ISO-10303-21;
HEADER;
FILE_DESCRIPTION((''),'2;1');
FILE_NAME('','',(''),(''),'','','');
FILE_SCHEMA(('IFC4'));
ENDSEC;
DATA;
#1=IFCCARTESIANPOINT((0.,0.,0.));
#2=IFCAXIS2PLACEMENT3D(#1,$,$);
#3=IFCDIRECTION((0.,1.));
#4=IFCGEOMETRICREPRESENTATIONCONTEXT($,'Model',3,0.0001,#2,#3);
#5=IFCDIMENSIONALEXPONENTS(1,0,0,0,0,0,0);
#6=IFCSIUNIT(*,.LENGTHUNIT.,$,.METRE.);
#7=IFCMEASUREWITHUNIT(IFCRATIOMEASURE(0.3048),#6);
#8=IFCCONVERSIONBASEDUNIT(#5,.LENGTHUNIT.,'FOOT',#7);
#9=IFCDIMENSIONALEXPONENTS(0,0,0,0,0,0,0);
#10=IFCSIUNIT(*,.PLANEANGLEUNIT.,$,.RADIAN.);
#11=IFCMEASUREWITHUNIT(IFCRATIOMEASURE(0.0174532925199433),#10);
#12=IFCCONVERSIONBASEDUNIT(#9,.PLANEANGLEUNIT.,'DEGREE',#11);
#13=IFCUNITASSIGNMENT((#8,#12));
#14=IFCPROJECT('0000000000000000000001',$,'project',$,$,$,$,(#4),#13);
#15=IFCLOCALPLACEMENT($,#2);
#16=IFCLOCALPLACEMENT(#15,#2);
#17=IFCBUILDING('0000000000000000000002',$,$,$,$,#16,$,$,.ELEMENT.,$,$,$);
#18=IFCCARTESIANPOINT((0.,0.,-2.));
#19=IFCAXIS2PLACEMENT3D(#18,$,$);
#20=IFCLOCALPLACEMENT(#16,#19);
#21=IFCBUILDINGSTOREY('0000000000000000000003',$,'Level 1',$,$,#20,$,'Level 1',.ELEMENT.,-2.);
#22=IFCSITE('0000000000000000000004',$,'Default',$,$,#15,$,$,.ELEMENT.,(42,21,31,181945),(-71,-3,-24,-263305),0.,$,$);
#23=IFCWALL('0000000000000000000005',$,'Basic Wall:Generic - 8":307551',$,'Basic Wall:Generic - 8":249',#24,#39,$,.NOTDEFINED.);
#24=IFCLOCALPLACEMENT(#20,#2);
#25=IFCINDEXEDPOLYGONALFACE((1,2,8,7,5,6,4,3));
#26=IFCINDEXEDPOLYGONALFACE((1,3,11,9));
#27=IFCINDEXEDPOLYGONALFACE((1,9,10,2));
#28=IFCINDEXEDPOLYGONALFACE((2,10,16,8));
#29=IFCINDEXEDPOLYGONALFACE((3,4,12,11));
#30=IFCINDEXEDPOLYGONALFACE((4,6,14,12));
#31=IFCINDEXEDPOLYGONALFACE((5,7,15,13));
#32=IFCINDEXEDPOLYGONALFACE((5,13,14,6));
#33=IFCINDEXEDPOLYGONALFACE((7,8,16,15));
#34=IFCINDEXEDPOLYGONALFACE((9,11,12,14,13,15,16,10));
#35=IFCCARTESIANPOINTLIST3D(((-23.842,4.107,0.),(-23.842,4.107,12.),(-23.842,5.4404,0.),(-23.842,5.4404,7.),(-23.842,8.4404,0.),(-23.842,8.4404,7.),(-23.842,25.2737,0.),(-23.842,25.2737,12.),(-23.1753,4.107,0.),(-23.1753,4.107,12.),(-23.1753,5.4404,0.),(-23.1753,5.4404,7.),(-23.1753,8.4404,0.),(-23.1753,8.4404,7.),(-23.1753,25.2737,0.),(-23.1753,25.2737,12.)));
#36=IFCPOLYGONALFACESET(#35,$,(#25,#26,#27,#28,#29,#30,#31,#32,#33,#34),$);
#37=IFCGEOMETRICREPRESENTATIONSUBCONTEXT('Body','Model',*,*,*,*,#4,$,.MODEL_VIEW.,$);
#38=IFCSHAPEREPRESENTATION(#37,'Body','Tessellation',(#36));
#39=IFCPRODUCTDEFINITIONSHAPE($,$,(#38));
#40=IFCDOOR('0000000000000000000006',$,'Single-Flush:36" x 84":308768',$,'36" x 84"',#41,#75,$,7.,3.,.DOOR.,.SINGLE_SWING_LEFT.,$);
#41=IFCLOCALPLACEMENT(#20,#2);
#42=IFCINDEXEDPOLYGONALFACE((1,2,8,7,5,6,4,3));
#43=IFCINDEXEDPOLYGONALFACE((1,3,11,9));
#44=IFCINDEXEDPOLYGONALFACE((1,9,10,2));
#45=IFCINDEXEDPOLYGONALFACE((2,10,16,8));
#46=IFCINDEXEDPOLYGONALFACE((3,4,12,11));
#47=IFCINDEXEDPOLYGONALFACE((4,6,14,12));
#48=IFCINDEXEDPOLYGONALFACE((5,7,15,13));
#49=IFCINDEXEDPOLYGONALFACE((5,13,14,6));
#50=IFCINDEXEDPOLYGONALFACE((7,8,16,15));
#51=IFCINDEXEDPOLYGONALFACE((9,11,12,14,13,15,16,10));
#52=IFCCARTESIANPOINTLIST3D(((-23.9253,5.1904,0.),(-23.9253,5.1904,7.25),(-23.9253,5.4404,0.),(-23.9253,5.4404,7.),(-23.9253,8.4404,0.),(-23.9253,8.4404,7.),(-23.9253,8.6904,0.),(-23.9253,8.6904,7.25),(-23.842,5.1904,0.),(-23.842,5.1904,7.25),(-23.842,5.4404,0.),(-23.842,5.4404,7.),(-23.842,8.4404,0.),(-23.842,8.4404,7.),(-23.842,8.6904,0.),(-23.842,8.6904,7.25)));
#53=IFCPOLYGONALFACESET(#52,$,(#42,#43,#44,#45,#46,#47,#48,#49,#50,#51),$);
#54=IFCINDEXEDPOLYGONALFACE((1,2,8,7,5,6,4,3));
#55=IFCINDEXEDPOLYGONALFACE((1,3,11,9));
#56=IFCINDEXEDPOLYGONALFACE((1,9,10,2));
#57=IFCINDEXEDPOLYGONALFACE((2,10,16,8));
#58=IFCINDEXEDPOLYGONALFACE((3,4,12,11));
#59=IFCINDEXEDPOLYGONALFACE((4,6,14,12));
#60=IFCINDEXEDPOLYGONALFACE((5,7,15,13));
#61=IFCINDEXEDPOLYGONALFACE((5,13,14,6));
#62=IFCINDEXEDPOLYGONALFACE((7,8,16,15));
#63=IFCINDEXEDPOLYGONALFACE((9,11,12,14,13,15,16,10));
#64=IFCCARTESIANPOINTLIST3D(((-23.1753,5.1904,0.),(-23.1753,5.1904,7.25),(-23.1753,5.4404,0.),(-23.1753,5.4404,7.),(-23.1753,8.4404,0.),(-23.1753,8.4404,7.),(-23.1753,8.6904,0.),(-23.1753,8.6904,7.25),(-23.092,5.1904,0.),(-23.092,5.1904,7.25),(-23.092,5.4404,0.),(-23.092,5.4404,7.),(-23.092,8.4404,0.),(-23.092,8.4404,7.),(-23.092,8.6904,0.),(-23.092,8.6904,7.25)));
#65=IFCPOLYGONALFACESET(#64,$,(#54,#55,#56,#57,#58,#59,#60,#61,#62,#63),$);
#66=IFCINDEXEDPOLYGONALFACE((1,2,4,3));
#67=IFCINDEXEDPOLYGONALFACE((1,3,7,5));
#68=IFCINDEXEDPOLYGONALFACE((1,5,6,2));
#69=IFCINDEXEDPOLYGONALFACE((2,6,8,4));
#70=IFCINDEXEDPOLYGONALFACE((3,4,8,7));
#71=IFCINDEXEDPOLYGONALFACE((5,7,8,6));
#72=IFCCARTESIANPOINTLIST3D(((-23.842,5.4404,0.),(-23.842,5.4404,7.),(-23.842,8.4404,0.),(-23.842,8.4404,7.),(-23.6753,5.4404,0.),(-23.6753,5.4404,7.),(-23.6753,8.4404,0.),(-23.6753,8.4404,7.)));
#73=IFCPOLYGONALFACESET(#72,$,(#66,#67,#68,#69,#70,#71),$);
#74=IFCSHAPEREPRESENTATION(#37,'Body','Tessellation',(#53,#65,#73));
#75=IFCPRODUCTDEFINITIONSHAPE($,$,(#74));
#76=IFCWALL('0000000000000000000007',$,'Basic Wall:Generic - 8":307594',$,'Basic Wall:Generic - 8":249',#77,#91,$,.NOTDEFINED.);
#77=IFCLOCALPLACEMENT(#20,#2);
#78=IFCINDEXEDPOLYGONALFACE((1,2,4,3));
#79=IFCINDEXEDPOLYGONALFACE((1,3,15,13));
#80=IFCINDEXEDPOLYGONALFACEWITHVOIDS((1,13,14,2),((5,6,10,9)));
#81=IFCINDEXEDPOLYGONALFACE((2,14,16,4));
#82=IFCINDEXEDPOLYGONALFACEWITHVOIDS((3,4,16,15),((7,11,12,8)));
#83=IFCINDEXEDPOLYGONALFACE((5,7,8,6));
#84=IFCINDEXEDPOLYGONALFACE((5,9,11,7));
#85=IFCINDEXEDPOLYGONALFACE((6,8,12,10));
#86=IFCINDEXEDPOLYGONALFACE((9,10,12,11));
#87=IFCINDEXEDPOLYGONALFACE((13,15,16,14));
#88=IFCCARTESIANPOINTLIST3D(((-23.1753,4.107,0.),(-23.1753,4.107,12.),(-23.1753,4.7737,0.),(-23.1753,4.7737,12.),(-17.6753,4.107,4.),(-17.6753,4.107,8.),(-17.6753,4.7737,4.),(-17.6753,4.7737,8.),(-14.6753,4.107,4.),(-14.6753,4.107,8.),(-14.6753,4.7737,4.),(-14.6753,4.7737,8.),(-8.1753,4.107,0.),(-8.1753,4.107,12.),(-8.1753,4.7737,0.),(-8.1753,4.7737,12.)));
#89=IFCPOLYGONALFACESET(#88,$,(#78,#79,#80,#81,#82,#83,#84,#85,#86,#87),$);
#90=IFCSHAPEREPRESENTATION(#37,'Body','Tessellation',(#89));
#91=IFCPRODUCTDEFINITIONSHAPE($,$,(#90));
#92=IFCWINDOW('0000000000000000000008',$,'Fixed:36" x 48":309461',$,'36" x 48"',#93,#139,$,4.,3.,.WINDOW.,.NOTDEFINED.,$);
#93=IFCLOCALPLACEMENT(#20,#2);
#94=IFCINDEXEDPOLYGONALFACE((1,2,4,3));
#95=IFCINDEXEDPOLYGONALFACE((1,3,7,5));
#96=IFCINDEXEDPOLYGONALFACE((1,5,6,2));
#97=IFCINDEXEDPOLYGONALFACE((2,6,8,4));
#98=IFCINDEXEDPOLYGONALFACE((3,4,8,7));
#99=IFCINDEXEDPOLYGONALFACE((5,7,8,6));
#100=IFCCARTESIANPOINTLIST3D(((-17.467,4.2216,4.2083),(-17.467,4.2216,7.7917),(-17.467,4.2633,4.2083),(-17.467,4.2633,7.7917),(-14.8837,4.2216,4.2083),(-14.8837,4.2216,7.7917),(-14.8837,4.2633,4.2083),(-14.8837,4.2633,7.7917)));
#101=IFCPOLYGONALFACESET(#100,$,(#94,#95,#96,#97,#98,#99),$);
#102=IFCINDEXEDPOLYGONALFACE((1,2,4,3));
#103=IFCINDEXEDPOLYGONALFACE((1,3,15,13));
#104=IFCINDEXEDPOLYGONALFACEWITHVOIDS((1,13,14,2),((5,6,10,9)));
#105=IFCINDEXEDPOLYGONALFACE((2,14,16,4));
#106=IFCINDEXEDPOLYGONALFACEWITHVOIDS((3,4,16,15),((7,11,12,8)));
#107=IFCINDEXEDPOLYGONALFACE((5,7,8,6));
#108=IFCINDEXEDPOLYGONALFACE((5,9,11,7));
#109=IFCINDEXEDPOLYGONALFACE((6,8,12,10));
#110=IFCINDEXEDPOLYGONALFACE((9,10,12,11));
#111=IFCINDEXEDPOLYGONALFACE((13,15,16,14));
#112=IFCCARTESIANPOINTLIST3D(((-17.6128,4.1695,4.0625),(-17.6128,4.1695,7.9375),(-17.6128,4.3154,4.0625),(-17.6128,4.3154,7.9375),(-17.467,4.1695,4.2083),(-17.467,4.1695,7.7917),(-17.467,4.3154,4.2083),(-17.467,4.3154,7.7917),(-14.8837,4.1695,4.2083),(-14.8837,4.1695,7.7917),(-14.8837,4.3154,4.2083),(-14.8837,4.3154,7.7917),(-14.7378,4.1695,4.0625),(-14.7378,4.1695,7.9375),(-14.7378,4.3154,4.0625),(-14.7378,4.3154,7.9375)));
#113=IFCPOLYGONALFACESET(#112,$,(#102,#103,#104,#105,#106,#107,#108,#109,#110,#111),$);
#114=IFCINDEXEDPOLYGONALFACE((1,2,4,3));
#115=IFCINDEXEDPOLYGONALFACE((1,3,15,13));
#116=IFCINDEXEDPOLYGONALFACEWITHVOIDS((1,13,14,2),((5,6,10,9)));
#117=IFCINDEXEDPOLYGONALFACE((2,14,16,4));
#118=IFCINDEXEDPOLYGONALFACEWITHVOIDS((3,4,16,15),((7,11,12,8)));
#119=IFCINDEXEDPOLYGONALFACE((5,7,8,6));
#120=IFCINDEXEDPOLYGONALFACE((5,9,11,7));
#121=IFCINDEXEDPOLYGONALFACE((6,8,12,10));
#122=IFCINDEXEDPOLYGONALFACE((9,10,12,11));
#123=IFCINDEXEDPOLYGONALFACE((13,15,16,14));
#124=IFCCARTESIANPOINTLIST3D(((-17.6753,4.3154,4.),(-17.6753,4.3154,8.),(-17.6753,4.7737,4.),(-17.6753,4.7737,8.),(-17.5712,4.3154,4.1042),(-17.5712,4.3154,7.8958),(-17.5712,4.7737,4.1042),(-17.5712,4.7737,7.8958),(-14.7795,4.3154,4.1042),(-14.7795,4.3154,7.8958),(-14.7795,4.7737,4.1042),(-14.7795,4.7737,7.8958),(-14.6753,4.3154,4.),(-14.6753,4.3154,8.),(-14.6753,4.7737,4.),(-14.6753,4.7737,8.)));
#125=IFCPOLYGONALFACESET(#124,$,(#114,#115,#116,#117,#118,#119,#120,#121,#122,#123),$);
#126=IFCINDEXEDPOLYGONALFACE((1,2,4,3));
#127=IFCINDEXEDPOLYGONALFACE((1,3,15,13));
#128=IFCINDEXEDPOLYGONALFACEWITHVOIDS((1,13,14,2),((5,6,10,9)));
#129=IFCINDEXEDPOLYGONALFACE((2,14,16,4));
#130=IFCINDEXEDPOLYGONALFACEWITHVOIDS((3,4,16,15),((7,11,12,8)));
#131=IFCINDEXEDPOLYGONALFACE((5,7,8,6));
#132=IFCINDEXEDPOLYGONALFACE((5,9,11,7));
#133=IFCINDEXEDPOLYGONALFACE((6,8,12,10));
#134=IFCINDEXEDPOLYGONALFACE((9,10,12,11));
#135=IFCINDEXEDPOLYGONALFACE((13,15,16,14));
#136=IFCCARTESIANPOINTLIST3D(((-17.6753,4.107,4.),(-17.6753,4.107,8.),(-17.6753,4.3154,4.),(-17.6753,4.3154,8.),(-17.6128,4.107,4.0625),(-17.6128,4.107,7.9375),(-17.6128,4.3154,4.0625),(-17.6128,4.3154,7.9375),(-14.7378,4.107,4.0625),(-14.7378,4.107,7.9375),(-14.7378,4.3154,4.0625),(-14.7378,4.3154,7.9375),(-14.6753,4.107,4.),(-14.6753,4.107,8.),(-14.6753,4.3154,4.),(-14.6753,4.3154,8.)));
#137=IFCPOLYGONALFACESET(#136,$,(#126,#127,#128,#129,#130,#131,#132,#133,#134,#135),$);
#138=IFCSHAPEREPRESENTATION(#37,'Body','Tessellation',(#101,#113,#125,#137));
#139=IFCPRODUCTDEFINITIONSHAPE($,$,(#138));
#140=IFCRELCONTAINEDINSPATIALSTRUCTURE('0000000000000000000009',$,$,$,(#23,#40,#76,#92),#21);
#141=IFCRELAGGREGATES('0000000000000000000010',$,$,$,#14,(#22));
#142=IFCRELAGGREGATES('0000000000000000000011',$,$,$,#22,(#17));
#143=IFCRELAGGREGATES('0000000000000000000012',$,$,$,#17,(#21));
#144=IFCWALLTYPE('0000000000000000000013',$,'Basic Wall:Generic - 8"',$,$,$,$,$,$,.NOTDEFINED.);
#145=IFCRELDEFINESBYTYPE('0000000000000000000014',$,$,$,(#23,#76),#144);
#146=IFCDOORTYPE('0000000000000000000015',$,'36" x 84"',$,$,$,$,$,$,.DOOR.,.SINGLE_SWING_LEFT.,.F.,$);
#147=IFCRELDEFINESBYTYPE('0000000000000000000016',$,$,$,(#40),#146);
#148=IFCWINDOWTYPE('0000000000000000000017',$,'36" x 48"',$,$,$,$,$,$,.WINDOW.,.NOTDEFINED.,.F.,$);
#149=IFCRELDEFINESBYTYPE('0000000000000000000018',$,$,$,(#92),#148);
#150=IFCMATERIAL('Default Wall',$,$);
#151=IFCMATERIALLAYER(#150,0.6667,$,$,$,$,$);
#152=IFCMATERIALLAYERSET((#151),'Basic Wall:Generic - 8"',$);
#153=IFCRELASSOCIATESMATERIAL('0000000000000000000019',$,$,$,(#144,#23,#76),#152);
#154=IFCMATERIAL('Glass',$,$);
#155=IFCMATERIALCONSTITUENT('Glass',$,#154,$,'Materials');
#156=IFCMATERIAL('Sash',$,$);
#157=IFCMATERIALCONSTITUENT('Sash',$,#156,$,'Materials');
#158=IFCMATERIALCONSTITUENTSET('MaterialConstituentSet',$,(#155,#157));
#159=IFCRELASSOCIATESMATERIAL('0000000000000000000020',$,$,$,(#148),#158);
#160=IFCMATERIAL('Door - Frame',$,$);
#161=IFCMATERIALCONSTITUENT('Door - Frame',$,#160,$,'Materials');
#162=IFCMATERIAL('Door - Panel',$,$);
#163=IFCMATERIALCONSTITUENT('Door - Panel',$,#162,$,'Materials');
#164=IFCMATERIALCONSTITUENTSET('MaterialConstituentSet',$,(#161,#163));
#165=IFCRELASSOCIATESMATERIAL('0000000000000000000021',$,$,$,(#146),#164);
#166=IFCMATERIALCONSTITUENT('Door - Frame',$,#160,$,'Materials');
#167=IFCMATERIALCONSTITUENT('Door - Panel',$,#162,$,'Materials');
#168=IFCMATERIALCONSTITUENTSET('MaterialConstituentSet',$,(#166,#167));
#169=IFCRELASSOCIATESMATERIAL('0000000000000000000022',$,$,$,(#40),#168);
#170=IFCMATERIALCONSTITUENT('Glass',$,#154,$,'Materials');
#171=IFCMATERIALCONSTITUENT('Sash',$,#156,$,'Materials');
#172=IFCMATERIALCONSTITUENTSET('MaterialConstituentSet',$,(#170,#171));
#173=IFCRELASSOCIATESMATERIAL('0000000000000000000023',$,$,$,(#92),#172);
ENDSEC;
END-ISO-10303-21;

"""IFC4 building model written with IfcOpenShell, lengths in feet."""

from ifc_helpers import new_model, entity, si_unit, converted_unit, direction, frame, frame_2d, origin, place, context, subcontext, project, spatial, polyline, rectangle, outline, extrude, source, transform, mapped, material, layer, layer_set, layer_usage, constituent, constituent_set, type_object, type_shapes, element, fill, save


model = new_model("IFC4")

# Units and contexts
model_context = context("Model", 3, precision=0.0001, world=origin(), true_north=direction((0.0, 1.0)))
body_context = subcontext(model_context, "Body", "Model", "MODEL_VIEW")
ifc_project = project(units=[converted_unit("LENGTHUNIT", "FOOT", entity("IfcRatioMeasure", 0.3048), si_unit("LENGTHUNIT", "METRE"), dimensions=[1, 0, 0, 0, 0, 0, 0]), converted_unit("PLANEANGLEUNIT", "DEGREE", entity("IfcRatioMeasure", 0.0174532925199433), si_unit("PLANEANGLEUNIT", "RADIAN"), dimensions=[0, 0, 0, 0, 0, 0, 0])], contexts=[model_context])

# Site, building, storey
site_placement = place(None, origin())
site = spatial("IfcSite", under=ifc_project, at=site_placement, Name="Default", CompositionType="ELEMENT", RefLatitude=(42, 21, 31, 181945), RefLongitude=(-71, -3, -24, -263305), RefElevation=0.0)
building_placement = place(site_placement, origin())
building = spatial("IfcBuilding", under=site, at=building_placement, CompositionType="ELEMENT")
storey_placement = place(building_placement, frame((0.0, 0.0, -2.0)))
storey = spatial("IfcBuildingStorey", under=building, at=storey_placement, Name="Level 1", LongName="Level 1", CompositionType="ELEMENT", Elevation=-2.0)

# Shared definitions
ifc_material_1 = material(Name="Default Wall")
ifc_layer = layer(ifc_material_1, 0.6667)
ifc_layer_set = layer_set([ifc_layer], Name="Basic Wall:Generic - 8\"")
wall_type = type_object("IfcWallType", Name="Basic Wall:Generic - 8\"", PredefinedType="NOTDEFINED", material=ifc_layer_set)
ifc_material_2 = material(Name="Glass")
ifc_material_3 = material(Name="Sash")
ifc_constituent_1 = constituent(ifc_material_2, Name="Glass", Category="Materials")
ifc_constituent_2 = constituent(ifc_material_3, Name="Sash", Category="Materials")
ifc_constituent_set_1 = constituent_set(constituents=[ifc_constituent_1, ifc_constituent_2], Name="MaterialConstituentSet")
window_type_1 = type_object("IfcWindowType", Name="36\" x 48\"", ParameterTakesPrecedence=False, PartitioningType="NOTDEFINED", PredefinedType="WINDOW", material=ifc_constituent_set_1)
shared_shape_1 = source(origin(), body_context, "Body", "SweptSolid", [
    extrude(rectangle(XDim=0.0417, YDim=2.5833, at=frame_2d((0.0, 0.0), x_axis=(1.0, 0.0))), frame((1.5, 0.5312, 0.2083), z_axis=(0.0, 0.0, 1.0), x_axis=(0.0, 1.0, 0.0)), (0.0, 0.0, 1.0), 3.5833),
    extrude(outline(polyline([(-1.4375, -1.9375), (1.4375, -1.9375), (1.4375, 1.9375), (-1.4375, 1.9375), (-1.4375, -1.9375)]), holes=[polyline([(-1.2917, -1.7917), (-1.2917, 1.7917), (1.2917, 1.7917), (1.2917, -1.7917), (-1.2917, -1.7917)])]), frame((1.5, 0.4583, 2.0), z_axis=(0.0, 1.0, 0.0), x_axis=(1.0, 0.0, 0.0)), (0.0, 0.0, 1.0), 0.1458),
    extrude(outline(polyline([(-1.5, -2.0), (1.5, -2.0), (1.5, 2.0), (-1.5, 2.0), (-1.5, -2.0)]), holes=[polyline([(-1.3958, -1.8958), (-1.3958, 1.8958), (1.3958, 1.8958), (1.3958, -1.8958), (-1.3958, -1.8958)])]), frame((1.5, 0.0, 2.0), z_axis=(0.0, 1.0, 0.0), x_axis=(1.0, 0.0, 0.0)), (0.0, 0.0, 1.0), 0.4583),
    extrude(outline(polyline([(-2.0, -1.5), (2.0, -1.5), (2.0, 1.5), (-2.0, 1.5), (-2.0, -1.5)]), holes=[polyline([(-1.9375, -1.4375), (-1.9375, 1.4375), (1.9375, 1.4375), (1.9375, -1.4375), (-1.9375, -1.4375)])]), frame((1.5, 0.4583, 2.0), z_axis=(0.0, 1.0, 0.0), x_axis=(0.0, 0.0, -1.0)), (0.0, 0.0, 1.0), 0.2083),
])
type_shapes(window_type_1, [shared_shape_1])

# Wall, opening, door
ifc_layer_usage_1 = layer_usage(ifc_layer_set, "AXIS2", "NEGATIVE", 0.3333)
wall_1_placement = place(storey_placement, frame((-23.5087, 25.2737, 0.0), z_axis=(0.0, 0.0, 1.0), x_axis=(0.0, -1.0, 0.0)))
wall_1 = element("IfcWall", 1, at=wall_1_placement, inside=storey, type_object=wall_type, material=ifc_layer_usage_1, Name="Basic Wall:Generic - 8\":307551", ObjectType="Basic Wall:Generic - 8\":249", PredefinedType="NOTDEFINED", context=body_context, shape_type="SweptSolid", body=[
    extrude(rectangle(XDim=21.1667, YDim=0.6667, at=frame_2d((10.5833, 0.0), x_axis=(-1.0, 0.0))), origin(), (0.0, 0.0, 1.0), 12.0),
])
opening_1_placement = place(wall_1_placement, frame((19.8333, 0.3333, 0.0)))
opening_1 = element("IfcOpeningElement", 2, at=opening_1_placement, cuts=wall_1, ObjectType="Opening", PredefinedType="OPENING", context=body_context, shape_type="SweptSolid", body=[
    extrude(rectangle(XDim=3.0, YDim=7.0, at=frame_2d((3.5, 1.5), x_axis=(0.0, -1.0))), frame((0.0, 0.0, 0.0), z_axis=(0.0, -1.0, 0.0), x_axis=(0.0, 0.0, 1.0)), (0.0, 0.0, 1.0), 0.6667),
])
ifc_material_4 = material(Name="Door - Frame")
ifc_constituent_3 = constituent(ifc_material_4, Name="Door - Frame", Category="Materials")
ifc_material_5 = material(Name="Door - Panel")
ifc_constituent_4 = constituent(ifc_material_5, Name="Door - Panel", Category="Materials")
ifc_constituent_set_2 = constituent_set(constituents=[ifc_constituent_3, ifc_constituent_4], Name="MaterialConstituentSet")
ifc_constituent_5 = constituent(ifc_material_4, Name="Door - Frame", Category="Materials")
ifc_constituent_6 = constituent(ifc_material_5, Name="Door - Panel", Category="Materials")
ifc_constituent_set_3 = constituent_set(constituents=[ifc_constituent_5, ifc_constituent_6], Name="MaterialConstituentSet")
door_type_1 = type_object("IfcDoorType", Name="36\" x 84\"", OperationType="SINGLE_SWING_LEFT", ParameterTakesPrecedence=False, PredefinedType="DOOR", material=ifc_constituent_set_3)
shared_shape_2 = source(origin(), body_context, "Body", "SweptSolid", [
    extrude(outline(polyline([(-1.75, -3.6875), (1.75, -3.6875), (1.75, 3.5625), (1.5, 3.5625), (1.5, -3.4375), (-1.5, -3.4375), (-1.5, 3.5625), (-1.75, 3.5625), (-1.75, -3.6875)])), frame((1.5, 0.75, 3.5625), z_axis=(0.0, -1.0, 0.0), x_axis=(-1.0, 0.0, 0.0)), (0.0, 0.0, 1.0), 0.0833),
    extrude(outline(polyline([(-3.6875, -1.75), (3.5625, -1.75), (3.5625, -1.5), (-3.4375, -1.5), (-3.4375, 1.5), (3.5625, 1.5), (3.5625, 1.75), (-3.6875, 1.75), (-3.6875, -1.75)])), frame((1.5, 0.0, 3.5625), z_axis=(0.0, -1.0, 0.0), x_axis=(0.0, 0.0, -1.0)), (0.0, 0.0, 1.0), 0.0833),
    extrude(rectangle(XDim=3.0, YDim=0.1667, at=frame_2d((0.0, 0.0), x_axis=(1.0, 0.0))), frame((1.5, 0.5833, 0.0)), (0.0, 0.0, 1.0), 7.0),
])
type_shapes(door_type_1, [shared_shape_2])
door_1_placement = place(opening_1_placement, frame((0.0, 0.0, 0.0), z_axis=(0.0, 0.0, 1.0), x_axis=(-1.0, 0.0, 0.0)))
door_1 = element("IfcDoor", 3, at=door_1_placement, inside=storey, type_object=door_type_1, material=ifc_constituent_set_2, Name="Single-Flush:36\" x 84\":308768", ObjectType="36\" x 84\"", OperationType="SINGLE_SWING_LEFT", OverallHeight=7.0, OverallWidth=3.0, PredefinedType="DOOR", context=body_context, shape_type="MappedRepresentation", body=[
    mapped(shared_shape_2, transform((0.0, 0.0, 0.0), scale=1.0)),
])
fill(opening_1, door_1)

# Wall, opening, window
ifc_layer_usage_2 = layer_usage(ifc_layer_set, "AXIS2", "NEGATIVE", 0.3333)
wall_2_placement = place(storey_placement, frame((-8.1753, 4.4404, 0.0), z_axis=(0.0, 0.0, 1.0), x_axis=(-1.0, 0.0, 0.0)))
wall_2 = element("IfcWall", 4, at=wall_2_placement, inside=storey, type_object=wall_type, material=ifc_layer_usage_2, Name="Basic Wall:Generic - 8\":307594", ObjectType="Basic Wall:Generic - 8\":249", PredefinedType="NOTDEFINED", context=body_context, shape_type="SweptSolid", body=[
    extrude(rectangle(XDim=15.0, YDim=0.6667, at=frame_2d((7.5, 0.0), x_axis=(-1.0, 0.0))), origin(), (0.0, 0.0, 1.0), 12.0),
])
opening_2_placement = place(wall_2_placement, frame((6.5, -0.3333, 4.0)))
opening_2 = element("IfcOpeningElement", 5, at=opening_2_placement, cuts=wall_2, ObjectType="Opening", PredefinedType="OPENING", context=body_context, shape_type="SweptSolid", body=[
    extrude(rectangle(XDim=4.0, YDim=3.0, at=frame_2d((2.0, 1.5), x_axis=(-1.0, 0.0))), frame((0.0, 0.0, 0.0), z_axis=(0.0, 1.0, 0.0), x_axis=(0.0, 0.0, 1.0)), (0.0, 0.0, 1.0), 0.6667),
])
ifc_constituent_7 = constituent(ifc_material_2, Name="Glass", Category="Materials")
ifc_constituent_8 = constituent(ifc_material_3, Name="Sash", Category="Materials")
ifc_constituent_set_4 = constituent_set(constituents=[ifc_constituent_7, ifc_constituent_8], Name="MaterialConstituentSet")
window_1_placement = place(opening_2_placement, origin())
window_1 = element("IfcWindow", 6, at=window_1_placement, inside=storey, type_object=window_type_1, material=ifc_constituent_set_4, Name="Fixed:36\" x 48\":309461", ObjectType="36\" x 48\"", OverallHeight=4.0, OverallWidth=3.0, PartitioningType="NOTDEFINED", PredefinedType="WINDOW", context=body_context, shape_type="MappedRepresentation", body=[
    mapped(shared_shape_1, transform((0.0, 0.0, 0.0), scale=1.0)),
])
fill(opening_2, window_1)

save(model, "model.ifc")
